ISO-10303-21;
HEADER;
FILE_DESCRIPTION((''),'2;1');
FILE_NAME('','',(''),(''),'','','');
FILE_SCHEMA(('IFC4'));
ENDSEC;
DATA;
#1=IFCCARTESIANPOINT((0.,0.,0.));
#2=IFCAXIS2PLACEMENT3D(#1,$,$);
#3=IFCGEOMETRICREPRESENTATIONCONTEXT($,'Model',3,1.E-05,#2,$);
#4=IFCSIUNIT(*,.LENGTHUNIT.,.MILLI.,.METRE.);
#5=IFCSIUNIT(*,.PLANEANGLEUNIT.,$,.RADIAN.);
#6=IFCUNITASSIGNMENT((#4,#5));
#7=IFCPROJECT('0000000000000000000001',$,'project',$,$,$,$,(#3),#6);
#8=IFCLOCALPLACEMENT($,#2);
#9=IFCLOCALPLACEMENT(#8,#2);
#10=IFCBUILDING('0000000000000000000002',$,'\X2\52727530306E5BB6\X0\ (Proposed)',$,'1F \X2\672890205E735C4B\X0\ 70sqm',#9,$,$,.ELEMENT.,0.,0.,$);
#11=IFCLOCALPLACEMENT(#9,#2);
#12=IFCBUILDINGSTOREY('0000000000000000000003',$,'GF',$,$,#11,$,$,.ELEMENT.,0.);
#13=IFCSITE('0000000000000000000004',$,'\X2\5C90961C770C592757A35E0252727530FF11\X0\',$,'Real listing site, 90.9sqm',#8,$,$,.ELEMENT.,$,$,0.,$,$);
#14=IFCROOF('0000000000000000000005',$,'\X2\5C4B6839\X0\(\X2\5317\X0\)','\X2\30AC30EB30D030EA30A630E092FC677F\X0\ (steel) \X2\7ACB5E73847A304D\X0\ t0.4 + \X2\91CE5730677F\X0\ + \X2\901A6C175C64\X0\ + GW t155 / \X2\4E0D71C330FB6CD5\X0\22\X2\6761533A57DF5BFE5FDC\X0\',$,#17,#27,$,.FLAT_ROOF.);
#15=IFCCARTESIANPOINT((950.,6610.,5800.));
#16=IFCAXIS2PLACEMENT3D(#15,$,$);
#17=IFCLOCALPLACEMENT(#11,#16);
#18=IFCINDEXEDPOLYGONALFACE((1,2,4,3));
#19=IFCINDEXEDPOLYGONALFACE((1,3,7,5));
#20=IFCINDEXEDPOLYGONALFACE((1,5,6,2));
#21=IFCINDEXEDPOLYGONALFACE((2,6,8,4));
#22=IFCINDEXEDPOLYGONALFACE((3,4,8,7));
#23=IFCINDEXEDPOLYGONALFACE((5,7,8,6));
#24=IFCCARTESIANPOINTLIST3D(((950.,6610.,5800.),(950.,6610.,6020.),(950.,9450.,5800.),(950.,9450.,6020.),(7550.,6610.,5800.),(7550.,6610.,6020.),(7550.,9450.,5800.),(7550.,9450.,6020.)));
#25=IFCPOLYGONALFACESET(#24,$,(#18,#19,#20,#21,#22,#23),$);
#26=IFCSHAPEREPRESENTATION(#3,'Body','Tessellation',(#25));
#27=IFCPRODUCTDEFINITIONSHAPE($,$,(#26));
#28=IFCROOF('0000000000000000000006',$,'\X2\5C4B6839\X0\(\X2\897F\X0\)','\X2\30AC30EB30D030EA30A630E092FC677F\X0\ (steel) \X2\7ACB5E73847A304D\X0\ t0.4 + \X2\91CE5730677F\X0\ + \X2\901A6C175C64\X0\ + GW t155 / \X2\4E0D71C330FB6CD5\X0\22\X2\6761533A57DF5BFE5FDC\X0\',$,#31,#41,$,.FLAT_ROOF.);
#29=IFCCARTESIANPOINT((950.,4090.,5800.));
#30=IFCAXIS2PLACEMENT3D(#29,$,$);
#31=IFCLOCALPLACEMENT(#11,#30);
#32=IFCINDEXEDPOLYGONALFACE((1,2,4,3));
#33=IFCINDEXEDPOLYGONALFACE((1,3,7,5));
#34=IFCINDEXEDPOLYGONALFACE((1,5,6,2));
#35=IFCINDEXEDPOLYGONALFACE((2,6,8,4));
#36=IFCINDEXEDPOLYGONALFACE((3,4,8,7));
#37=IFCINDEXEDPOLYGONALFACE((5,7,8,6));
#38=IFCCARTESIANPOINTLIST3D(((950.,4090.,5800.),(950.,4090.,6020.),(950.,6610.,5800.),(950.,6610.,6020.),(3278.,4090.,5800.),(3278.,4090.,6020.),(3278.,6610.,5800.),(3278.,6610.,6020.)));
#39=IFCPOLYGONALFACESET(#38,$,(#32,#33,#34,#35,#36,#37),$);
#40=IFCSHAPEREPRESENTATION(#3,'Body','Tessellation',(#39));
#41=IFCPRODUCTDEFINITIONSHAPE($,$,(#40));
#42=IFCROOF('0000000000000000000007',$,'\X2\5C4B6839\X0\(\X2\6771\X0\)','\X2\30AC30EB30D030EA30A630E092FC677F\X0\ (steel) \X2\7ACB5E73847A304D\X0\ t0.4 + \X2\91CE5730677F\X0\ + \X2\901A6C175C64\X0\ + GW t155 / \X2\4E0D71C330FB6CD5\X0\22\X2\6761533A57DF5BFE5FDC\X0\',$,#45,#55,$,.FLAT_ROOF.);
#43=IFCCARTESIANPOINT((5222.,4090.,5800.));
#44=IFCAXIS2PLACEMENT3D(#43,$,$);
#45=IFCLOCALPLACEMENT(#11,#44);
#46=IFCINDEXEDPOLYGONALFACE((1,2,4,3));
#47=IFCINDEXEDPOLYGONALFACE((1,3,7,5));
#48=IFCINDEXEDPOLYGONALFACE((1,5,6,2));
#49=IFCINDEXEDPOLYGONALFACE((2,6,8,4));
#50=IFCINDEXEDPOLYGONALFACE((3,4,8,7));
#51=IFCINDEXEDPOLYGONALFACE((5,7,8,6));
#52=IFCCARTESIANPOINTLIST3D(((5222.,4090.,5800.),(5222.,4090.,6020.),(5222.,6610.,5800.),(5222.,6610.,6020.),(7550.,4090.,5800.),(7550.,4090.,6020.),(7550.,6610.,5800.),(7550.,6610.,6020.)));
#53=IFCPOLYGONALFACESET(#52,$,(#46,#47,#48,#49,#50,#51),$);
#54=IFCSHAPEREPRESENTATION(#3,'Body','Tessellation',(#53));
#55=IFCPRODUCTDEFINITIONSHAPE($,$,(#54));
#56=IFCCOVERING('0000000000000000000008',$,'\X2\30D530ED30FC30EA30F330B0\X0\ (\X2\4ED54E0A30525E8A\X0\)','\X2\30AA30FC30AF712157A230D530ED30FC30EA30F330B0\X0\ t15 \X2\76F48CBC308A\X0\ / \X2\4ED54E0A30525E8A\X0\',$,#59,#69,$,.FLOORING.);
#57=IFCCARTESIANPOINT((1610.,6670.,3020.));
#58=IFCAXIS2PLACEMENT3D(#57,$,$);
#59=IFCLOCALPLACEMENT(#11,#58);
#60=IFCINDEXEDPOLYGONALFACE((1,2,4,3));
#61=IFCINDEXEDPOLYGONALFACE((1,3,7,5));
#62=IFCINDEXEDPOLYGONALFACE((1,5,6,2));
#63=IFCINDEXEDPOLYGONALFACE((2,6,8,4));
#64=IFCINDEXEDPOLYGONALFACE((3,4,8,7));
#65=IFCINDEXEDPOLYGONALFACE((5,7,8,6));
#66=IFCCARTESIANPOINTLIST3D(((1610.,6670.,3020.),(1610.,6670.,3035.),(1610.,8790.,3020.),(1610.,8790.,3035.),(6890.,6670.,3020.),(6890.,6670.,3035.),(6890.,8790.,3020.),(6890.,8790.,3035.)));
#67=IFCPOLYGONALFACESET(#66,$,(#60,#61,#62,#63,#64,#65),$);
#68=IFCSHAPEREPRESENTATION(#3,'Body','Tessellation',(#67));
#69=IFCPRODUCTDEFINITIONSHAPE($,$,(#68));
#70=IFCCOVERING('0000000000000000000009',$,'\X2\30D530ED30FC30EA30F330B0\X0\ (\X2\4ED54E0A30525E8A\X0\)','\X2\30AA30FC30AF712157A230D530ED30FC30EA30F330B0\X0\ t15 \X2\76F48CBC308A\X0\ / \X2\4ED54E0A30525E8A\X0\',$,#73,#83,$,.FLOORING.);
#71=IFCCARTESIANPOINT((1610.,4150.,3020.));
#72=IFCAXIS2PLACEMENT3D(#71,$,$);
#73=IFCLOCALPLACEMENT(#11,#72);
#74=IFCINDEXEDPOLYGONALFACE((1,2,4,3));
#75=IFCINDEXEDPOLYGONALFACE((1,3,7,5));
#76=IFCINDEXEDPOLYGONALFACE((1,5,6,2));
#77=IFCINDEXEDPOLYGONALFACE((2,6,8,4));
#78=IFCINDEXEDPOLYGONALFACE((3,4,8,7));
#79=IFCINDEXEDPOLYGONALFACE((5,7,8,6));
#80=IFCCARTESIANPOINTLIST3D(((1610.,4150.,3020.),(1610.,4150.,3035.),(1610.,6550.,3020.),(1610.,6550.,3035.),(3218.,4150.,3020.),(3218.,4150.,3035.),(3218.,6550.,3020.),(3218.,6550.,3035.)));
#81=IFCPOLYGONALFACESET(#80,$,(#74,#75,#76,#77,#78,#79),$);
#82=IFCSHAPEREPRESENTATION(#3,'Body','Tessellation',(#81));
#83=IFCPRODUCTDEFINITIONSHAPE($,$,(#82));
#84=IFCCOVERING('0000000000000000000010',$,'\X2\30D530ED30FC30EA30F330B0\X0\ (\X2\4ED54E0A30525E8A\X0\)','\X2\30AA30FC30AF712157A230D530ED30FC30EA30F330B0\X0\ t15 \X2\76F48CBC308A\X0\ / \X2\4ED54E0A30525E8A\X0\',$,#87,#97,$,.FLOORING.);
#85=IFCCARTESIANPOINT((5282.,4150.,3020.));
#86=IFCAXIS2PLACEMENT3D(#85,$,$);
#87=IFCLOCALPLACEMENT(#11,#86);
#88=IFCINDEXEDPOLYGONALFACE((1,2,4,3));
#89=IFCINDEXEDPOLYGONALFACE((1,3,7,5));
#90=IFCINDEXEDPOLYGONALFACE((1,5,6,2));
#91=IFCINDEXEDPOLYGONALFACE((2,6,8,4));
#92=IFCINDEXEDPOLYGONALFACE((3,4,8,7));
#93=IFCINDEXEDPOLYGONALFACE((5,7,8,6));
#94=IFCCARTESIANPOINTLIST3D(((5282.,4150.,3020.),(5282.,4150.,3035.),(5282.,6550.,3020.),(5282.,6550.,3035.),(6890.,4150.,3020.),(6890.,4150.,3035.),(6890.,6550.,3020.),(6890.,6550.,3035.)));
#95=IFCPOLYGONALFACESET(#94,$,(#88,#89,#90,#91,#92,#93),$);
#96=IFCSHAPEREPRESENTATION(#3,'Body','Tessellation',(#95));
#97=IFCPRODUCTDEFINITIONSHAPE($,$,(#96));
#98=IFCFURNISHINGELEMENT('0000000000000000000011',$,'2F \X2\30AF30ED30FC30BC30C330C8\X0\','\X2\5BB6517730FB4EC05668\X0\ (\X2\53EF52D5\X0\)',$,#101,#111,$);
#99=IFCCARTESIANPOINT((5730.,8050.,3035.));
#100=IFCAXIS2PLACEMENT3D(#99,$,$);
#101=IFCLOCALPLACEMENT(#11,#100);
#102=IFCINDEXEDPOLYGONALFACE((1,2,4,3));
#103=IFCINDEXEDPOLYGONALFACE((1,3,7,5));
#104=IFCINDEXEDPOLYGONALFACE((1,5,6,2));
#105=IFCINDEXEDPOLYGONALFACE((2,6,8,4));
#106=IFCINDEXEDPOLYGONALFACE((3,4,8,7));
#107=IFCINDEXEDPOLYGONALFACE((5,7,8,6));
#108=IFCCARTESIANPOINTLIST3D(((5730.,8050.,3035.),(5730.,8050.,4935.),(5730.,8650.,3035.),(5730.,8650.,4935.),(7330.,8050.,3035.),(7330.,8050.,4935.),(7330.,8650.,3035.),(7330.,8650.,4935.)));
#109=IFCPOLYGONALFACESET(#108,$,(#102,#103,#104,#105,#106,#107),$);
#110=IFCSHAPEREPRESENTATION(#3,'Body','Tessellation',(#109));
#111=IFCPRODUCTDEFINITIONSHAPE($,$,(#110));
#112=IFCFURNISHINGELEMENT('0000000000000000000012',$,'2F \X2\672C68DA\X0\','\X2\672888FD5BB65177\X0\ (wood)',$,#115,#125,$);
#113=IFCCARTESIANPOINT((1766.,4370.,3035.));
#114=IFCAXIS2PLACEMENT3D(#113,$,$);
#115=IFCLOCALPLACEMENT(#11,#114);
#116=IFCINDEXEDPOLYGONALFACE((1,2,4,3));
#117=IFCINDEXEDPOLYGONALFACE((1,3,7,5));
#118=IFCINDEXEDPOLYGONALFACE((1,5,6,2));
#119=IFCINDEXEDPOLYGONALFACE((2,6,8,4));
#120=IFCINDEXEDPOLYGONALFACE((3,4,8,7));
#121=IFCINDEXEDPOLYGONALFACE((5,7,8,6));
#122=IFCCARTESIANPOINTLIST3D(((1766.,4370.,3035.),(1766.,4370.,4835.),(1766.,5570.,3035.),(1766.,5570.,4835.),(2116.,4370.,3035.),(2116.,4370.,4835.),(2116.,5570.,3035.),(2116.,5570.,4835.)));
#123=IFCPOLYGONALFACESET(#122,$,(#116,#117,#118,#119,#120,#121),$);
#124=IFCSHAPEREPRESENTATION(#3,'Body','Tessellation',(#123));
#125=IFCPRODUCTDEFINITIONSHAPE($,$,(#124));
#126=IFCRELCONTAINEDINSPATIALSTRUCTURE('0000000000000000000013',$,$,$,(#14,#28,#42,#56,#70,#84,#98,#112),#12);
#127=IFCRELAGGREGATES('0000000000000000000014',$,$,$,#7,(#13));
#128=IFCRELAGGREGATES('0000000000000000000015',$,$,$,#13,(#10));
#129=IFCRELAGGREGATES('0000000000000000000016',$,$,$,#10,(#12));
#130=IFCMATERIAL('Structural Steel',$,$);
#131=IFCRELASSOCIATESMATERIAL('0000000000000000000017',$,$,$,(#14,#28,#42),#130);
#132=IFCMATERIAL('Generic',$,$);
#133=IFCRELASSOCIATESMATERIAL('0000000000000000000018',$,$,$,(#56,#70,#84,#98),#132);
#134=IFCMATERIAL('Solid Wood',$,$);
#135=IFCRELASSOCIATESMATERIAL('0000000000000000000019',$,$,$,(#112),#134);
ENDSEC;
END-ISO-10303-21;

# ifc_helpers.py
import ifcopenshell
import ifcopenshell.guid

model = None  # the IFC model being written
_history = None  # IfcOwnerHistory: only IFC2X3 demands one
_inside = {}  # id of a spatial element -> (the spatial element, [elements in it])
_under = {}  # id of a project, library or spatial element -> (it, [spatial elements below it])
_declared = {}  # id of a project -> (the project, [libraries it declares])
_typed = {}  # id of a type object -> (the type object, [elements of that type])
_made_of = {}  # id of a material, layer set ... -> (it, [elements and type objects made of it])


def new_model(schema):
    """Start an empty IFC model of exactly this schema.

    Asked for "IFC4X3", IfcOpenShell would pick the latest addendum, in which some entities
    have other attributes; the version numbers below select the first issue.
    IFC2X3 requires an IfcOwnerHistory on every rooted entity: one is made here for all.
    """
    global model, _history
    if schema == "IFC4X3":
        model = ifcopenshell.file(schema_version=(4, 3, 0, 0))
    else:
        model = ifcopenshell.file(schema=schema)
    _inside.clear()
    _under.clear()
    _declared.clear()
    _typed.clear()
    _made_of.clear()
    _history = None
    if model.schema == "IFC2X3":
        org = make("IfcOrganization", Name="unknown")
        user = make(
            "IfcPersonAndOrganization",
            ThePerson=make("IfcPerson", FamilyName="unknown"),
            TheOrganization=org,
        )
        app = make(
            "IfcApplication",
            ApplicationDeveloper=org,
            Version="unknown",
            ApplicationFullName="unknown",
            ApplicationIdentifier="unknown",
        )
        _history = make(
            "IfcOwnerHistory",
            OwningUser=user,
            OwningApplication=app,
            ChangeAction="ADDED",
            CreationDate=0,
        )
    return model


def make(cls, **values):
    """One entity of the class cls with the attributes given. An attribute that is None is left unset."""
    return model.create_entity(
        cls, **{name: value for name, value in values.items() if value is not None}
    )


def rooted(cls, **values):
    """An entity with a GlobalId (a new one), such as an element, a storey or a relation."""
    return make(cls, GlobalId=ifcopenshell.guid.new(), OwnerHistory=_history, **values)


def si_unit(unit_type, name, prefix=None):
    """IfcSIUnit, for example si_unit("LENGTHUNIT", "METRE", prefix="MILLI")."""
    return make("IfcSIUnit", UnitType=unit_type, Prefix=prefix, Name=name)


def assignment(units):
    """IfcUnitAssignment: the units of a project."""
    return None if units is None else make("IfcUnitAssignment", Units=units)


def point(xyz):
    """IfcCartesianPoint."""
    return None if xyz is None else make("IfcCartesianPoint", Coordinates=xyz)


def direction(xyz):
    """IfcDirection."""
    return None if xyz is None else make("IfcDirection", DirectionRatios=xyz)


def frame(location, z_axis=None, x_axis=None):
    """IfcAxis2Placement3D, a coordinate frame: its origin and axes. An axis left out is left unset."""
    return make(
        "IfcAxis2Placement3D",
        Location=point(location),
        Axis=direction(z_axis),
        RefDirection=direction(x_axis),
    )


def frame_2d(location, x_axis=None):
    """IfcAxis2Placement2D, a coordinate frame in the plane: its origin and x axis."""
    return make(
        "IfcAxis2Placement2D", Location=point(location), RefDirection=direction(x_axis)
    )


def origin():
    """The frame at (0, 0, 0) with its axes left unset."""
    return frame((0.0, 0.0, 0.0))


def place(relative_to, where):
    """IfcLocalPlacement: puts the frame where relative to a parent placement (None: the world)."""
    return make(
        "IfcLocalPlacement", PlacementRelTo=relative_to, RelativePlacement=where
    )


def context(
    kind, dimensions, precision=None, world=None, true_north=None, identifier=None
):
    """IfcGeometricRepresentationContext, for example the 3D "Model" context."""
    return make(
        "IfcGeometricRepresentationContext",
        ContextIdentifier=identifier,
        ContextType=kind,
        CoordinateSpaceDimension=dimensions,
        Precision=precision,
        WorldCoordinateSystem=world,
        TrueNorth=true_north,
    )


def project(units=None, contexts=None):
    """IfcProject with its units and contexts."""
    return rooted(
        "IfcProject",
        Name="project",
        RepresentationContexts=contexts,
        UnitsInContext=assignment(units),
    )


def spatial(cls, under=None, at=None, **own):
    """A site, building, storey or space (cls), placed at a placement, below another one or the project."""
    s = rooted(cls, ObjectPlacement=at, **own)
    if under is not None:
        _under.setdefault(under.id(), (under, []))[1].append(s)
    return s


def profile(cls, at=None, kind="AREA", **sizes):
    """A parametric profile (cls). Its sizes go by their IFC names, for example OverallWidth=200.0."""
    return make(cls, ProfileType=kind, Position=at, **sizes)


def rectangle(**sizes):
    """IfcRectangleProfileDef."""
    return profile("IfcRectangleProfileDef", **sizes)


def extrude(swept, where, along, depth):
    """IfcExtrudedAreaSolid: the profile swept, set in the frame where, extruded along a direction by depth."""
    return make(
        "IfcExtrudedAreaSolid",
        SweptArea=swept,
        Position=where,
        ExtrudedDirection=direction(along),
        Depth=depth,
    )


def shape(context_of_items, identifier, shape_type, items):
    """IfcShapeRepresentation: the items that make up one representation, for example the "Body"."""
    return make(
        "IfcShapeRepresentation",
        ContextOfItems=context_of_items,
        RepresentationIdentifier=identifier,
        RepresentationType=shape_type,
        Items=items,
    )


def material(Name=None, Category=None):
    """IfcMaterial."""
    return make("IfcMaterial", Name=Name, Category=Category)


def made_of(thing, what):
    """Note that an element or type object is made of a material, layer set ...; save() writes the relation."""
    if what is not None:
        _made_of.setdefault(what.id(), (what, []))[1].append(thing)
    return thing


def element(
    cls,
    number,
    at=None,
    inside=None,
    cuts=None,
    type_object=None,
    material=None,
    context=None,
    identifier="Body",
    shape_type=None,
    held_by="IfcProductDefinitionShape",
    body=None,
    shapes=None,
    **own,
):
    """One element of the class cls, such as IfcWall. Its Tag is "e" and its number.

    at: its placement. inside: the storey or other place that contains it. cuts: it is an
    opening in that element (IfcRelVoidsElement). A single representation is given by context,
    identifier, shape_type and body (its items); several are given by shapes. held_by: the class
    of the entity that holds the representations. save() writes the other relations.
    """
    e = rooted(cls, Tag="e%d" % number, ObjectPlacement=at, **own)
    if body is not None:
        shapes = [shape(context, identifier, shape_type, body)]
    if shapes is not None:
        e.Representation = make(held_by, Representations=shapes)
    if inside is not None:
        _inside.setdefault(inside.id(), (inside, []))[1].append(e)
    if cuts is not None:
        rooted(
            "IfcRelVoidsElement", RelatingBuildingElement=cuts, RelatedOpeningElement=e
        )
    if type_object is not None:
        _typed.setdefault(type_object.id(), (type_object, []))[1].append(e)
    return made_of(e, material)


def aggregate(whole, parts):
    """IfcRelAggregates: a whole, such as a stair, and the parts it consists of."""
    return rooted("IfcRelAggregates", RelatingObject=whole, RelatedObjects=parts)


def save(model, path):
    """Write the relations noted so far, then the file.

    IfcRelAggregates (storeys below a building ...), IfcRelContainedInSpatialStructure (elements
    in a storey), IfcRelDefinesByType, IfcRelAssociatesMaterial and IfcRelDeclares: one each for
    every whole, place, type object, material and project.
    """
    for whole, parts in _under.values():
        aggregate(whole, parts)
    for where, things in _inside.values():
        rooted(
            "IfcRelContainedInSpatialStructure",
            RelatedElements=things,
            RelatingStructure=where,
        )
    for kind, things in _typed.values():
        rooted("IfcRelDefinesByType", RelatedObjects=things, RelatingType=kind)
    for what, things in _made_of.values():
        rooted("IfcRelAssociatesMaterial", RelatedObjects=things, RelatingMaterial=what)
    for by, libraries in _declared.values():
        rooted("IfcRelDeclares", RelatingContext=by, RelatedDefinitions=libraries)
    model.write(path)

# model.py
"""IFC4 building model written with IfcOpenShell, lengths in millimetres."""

from ifc_helpers import new_model, si_unit, frame, frame_2d, origin, place, context, project, spatial, rectangle, extrude, material, element, save


model = new_model("IFC4")

# Units and contexts
model_context = context("Model", 3, precision=1e-05, world=origin())
ifc_project = project(units=[si_unit("LENGTHUNIT", "METRE", prefix="MILLI"), si_unit("PLANEANGLEUNIT", "RADIAN")], contexts=[model_context])

# Site, building, storey
site_placement = place(None, origin())
site = spatial("IfcSite", under=ifc_project, at=site_placement, Name="岐阜県大垣市割田１", ObjectType="Real listing site, 90.9sqm", CompositionType="ELEMENT", RefElevation=0.0)
building_placement = place(site_placement, origin())
building = spatial("IfcBuilding", under=site, at=building_placement, Name="割田の家 (Proposed)", ObjectType="1F 木造平屋 70sqm", CompositionType="ELEMENT", ElevationOfRefHeight=0.0, ElevationOfTerrain=0.0)
storey_placement = place(building_placement, origin())
storey = spatial("IfcBuildingStorey", under=building, at=storey_placement, Name="GF", CompositionType="ELEMENT", Elevation=0.0)

# Shared definitions
ifc_material_1 = material(Name="Solid Wood")

# Shared definitions
ifc_material_2 = material(Name="Generic")

# Roofs
ifc_material_3 = material(Name="Structural Steel")
for number, where, name in (
    (1, (950.0, 6610.0, 5800.0), "屋根(北)"),
):
    element("IfcRoof", number, at=place(storey_placement, frame(where)), inside=storey, material=ifc_material_3, Name=name, Description="ガルバリウム鋼板 (steel) 立平葺き t0.4 + 野地板 + 通気層 + GW t155 / 不燃・法22条区域対応", PredefinedType="FLAT_ROOF", context=model_context, shape_type="SweptSolid", body=[
        extrude(rectangle(XDim=6600.0, YDim=2840.0, at=frame_2d((3300.0, 1420.0))), frame((950.0, 6610.0, 5800.0)), (0.0, 0.0, 1.0), 220.0),
    ])
roof_1_placement = place(storey_placement, frame((950.0, 4090.0, 5800.0)))
element("IfcRoof", 2, at=roof_1_placement, inside=storey, material=ifc_material_3, Name="屋根(西)", Description="ガルバリウム鋼板 (steel) 立平葺き t0.4 + 野地板 + 通気層 + GW t155 / 不燃・法22条区域対応", PredefinedType="FLAT_ROOF", context=model_context, shape_type="SweptSolid", body=[
    extrude(rectangle(XDim=2328.0, YDim=2520.0, at=frame_2d((1164.0, 1260.0))), frame((950.0, 4090.0, 5800.0)), (0.0, 0.0, 1.0), 220.0),
])
roof_2_placement = place(storey_placement, frame((5222.0, 4090.0, 5800.0)))
element("IfcRoof", 3, at=roof_2_placement, inside=storey, material=ifc_material_3, Name="屋根(東)", Description="ガルバリウム鋼板 (steel) 立平葺き t0.4 + 野地板 + 通気層 + GW t155 / 不燃・法22条区域対応", PredefinedType="FLAT_ROOF", context=model_context, shape_type="SweptSolid", body=[
    extrude(rectangle(XDim=2328.0, YDim=2520.0, at=frame_2d((1164.0, 1260.0))), frame((5222.0, 4090.0, 5800.0)), (0.0, 0.0, 1.0), 220.0),
])

# Coverings
covering_1_placement = place(storey_placement, frame((1610.0, 6670.0, 3020.0)))
element("IfcCovering", 4, at=covering_1_placement, inside=storey, material=ifc_material_2, Name="フローリング (仕上げ床)", Description="オーク無垢フローリング t15 直貼り / 仕上げ床", PredefinedType="FLOORING", context=model_context, shape_type="SweptSolid", body=[
    extrude(rectangle(XDim=5280.0, YDim=2120.0, at=frame_2d((2640.0, 1060.0))), frame((1610.0, 6670.0, 3020.0)), (0.0, 0.0, 1.0), 15.0),
])
covering_2_placement = place(storey_placement, frame((1610.0, 4150.0, 3020.0)))
element("IfcCovering", 5, at=covering_2_placement, inside=storey, material=ifc_material_2, Name="フローリング (仕上げ床)", Description="オーク無垢フローリング t15 直貼り / 仕上げ床", PredefinedType="FLOORING", context=model_context, shape_type="SweptSolid", body=[
    extrude(rectangle(XDim=1608.0, YDim=2400.0, at=frame_2d((804.0, 1200.0))), frame((1610.0, 4150.0, 3020.0)), (0.0, 0.0, 1.0), 15.0),
])
covering_3_placement = place(storey_placement, frame((5282.0, 4150.0, 3020.0)))
element("IfcCovering", 6, at=covering_3_placement, inside=storey, material=ifc_material_2, Name="フローリング (仕上げ床)", Description="オーク無垢フローリング t15 直貼り / 仕上げ床", PredefinedType="FLOORING", context=model_context, shape_type="SweptSolid", body=[
    extrude(rectangle(XDim=1608.0, YDim=2400.0, at=frame_2d((804.0, 1200.0))), frame((5282.0, 4150.0, 3020.0)), (0.0, 0.0, 1.0), 15.0),
])

# Furnishing elements
furnishing_1_placement = place(storey_placement, frame((5730.0, 8050.0, 3035.0)))
element("IfcFurnishingElement", 7, at=furnishing_1_placement, inside=storey, material=ifc_material_2, Name="2F クローゼット", Description="家具・什器 (可動)", context=model_context, shape_type="SweptSolid", body=[
    extrude(rectangle(XDim=1600.0, YDim=600.0, at=frame_2d((800.0, 300.0))), frame((5730.0, 8050.0, 3035.0)), (0.0, 0.0, 1.0), 1900.0),
])
furnishing_2_placement = place(storey_placement, frame((1766.0, 4370.0, 3035.0)))
element("IfcFurnishingElement", 8, at=furnishing_2_placement, inside=storey, material=ifc_material_1, Name="2F 本棚", Description="木製家具 (wood)", context=model_context, shape_type="SweptSolid", body=[
    extrude(rectangle(XDim=350.0, YDim=1200.0, at=frame_2d((175.0, 600.0))), frame((1766.0, 4370.0, 3035.0)), (0.0, 0.0, 1.0), 1800.0),
])

save(model, "model.ifc")
